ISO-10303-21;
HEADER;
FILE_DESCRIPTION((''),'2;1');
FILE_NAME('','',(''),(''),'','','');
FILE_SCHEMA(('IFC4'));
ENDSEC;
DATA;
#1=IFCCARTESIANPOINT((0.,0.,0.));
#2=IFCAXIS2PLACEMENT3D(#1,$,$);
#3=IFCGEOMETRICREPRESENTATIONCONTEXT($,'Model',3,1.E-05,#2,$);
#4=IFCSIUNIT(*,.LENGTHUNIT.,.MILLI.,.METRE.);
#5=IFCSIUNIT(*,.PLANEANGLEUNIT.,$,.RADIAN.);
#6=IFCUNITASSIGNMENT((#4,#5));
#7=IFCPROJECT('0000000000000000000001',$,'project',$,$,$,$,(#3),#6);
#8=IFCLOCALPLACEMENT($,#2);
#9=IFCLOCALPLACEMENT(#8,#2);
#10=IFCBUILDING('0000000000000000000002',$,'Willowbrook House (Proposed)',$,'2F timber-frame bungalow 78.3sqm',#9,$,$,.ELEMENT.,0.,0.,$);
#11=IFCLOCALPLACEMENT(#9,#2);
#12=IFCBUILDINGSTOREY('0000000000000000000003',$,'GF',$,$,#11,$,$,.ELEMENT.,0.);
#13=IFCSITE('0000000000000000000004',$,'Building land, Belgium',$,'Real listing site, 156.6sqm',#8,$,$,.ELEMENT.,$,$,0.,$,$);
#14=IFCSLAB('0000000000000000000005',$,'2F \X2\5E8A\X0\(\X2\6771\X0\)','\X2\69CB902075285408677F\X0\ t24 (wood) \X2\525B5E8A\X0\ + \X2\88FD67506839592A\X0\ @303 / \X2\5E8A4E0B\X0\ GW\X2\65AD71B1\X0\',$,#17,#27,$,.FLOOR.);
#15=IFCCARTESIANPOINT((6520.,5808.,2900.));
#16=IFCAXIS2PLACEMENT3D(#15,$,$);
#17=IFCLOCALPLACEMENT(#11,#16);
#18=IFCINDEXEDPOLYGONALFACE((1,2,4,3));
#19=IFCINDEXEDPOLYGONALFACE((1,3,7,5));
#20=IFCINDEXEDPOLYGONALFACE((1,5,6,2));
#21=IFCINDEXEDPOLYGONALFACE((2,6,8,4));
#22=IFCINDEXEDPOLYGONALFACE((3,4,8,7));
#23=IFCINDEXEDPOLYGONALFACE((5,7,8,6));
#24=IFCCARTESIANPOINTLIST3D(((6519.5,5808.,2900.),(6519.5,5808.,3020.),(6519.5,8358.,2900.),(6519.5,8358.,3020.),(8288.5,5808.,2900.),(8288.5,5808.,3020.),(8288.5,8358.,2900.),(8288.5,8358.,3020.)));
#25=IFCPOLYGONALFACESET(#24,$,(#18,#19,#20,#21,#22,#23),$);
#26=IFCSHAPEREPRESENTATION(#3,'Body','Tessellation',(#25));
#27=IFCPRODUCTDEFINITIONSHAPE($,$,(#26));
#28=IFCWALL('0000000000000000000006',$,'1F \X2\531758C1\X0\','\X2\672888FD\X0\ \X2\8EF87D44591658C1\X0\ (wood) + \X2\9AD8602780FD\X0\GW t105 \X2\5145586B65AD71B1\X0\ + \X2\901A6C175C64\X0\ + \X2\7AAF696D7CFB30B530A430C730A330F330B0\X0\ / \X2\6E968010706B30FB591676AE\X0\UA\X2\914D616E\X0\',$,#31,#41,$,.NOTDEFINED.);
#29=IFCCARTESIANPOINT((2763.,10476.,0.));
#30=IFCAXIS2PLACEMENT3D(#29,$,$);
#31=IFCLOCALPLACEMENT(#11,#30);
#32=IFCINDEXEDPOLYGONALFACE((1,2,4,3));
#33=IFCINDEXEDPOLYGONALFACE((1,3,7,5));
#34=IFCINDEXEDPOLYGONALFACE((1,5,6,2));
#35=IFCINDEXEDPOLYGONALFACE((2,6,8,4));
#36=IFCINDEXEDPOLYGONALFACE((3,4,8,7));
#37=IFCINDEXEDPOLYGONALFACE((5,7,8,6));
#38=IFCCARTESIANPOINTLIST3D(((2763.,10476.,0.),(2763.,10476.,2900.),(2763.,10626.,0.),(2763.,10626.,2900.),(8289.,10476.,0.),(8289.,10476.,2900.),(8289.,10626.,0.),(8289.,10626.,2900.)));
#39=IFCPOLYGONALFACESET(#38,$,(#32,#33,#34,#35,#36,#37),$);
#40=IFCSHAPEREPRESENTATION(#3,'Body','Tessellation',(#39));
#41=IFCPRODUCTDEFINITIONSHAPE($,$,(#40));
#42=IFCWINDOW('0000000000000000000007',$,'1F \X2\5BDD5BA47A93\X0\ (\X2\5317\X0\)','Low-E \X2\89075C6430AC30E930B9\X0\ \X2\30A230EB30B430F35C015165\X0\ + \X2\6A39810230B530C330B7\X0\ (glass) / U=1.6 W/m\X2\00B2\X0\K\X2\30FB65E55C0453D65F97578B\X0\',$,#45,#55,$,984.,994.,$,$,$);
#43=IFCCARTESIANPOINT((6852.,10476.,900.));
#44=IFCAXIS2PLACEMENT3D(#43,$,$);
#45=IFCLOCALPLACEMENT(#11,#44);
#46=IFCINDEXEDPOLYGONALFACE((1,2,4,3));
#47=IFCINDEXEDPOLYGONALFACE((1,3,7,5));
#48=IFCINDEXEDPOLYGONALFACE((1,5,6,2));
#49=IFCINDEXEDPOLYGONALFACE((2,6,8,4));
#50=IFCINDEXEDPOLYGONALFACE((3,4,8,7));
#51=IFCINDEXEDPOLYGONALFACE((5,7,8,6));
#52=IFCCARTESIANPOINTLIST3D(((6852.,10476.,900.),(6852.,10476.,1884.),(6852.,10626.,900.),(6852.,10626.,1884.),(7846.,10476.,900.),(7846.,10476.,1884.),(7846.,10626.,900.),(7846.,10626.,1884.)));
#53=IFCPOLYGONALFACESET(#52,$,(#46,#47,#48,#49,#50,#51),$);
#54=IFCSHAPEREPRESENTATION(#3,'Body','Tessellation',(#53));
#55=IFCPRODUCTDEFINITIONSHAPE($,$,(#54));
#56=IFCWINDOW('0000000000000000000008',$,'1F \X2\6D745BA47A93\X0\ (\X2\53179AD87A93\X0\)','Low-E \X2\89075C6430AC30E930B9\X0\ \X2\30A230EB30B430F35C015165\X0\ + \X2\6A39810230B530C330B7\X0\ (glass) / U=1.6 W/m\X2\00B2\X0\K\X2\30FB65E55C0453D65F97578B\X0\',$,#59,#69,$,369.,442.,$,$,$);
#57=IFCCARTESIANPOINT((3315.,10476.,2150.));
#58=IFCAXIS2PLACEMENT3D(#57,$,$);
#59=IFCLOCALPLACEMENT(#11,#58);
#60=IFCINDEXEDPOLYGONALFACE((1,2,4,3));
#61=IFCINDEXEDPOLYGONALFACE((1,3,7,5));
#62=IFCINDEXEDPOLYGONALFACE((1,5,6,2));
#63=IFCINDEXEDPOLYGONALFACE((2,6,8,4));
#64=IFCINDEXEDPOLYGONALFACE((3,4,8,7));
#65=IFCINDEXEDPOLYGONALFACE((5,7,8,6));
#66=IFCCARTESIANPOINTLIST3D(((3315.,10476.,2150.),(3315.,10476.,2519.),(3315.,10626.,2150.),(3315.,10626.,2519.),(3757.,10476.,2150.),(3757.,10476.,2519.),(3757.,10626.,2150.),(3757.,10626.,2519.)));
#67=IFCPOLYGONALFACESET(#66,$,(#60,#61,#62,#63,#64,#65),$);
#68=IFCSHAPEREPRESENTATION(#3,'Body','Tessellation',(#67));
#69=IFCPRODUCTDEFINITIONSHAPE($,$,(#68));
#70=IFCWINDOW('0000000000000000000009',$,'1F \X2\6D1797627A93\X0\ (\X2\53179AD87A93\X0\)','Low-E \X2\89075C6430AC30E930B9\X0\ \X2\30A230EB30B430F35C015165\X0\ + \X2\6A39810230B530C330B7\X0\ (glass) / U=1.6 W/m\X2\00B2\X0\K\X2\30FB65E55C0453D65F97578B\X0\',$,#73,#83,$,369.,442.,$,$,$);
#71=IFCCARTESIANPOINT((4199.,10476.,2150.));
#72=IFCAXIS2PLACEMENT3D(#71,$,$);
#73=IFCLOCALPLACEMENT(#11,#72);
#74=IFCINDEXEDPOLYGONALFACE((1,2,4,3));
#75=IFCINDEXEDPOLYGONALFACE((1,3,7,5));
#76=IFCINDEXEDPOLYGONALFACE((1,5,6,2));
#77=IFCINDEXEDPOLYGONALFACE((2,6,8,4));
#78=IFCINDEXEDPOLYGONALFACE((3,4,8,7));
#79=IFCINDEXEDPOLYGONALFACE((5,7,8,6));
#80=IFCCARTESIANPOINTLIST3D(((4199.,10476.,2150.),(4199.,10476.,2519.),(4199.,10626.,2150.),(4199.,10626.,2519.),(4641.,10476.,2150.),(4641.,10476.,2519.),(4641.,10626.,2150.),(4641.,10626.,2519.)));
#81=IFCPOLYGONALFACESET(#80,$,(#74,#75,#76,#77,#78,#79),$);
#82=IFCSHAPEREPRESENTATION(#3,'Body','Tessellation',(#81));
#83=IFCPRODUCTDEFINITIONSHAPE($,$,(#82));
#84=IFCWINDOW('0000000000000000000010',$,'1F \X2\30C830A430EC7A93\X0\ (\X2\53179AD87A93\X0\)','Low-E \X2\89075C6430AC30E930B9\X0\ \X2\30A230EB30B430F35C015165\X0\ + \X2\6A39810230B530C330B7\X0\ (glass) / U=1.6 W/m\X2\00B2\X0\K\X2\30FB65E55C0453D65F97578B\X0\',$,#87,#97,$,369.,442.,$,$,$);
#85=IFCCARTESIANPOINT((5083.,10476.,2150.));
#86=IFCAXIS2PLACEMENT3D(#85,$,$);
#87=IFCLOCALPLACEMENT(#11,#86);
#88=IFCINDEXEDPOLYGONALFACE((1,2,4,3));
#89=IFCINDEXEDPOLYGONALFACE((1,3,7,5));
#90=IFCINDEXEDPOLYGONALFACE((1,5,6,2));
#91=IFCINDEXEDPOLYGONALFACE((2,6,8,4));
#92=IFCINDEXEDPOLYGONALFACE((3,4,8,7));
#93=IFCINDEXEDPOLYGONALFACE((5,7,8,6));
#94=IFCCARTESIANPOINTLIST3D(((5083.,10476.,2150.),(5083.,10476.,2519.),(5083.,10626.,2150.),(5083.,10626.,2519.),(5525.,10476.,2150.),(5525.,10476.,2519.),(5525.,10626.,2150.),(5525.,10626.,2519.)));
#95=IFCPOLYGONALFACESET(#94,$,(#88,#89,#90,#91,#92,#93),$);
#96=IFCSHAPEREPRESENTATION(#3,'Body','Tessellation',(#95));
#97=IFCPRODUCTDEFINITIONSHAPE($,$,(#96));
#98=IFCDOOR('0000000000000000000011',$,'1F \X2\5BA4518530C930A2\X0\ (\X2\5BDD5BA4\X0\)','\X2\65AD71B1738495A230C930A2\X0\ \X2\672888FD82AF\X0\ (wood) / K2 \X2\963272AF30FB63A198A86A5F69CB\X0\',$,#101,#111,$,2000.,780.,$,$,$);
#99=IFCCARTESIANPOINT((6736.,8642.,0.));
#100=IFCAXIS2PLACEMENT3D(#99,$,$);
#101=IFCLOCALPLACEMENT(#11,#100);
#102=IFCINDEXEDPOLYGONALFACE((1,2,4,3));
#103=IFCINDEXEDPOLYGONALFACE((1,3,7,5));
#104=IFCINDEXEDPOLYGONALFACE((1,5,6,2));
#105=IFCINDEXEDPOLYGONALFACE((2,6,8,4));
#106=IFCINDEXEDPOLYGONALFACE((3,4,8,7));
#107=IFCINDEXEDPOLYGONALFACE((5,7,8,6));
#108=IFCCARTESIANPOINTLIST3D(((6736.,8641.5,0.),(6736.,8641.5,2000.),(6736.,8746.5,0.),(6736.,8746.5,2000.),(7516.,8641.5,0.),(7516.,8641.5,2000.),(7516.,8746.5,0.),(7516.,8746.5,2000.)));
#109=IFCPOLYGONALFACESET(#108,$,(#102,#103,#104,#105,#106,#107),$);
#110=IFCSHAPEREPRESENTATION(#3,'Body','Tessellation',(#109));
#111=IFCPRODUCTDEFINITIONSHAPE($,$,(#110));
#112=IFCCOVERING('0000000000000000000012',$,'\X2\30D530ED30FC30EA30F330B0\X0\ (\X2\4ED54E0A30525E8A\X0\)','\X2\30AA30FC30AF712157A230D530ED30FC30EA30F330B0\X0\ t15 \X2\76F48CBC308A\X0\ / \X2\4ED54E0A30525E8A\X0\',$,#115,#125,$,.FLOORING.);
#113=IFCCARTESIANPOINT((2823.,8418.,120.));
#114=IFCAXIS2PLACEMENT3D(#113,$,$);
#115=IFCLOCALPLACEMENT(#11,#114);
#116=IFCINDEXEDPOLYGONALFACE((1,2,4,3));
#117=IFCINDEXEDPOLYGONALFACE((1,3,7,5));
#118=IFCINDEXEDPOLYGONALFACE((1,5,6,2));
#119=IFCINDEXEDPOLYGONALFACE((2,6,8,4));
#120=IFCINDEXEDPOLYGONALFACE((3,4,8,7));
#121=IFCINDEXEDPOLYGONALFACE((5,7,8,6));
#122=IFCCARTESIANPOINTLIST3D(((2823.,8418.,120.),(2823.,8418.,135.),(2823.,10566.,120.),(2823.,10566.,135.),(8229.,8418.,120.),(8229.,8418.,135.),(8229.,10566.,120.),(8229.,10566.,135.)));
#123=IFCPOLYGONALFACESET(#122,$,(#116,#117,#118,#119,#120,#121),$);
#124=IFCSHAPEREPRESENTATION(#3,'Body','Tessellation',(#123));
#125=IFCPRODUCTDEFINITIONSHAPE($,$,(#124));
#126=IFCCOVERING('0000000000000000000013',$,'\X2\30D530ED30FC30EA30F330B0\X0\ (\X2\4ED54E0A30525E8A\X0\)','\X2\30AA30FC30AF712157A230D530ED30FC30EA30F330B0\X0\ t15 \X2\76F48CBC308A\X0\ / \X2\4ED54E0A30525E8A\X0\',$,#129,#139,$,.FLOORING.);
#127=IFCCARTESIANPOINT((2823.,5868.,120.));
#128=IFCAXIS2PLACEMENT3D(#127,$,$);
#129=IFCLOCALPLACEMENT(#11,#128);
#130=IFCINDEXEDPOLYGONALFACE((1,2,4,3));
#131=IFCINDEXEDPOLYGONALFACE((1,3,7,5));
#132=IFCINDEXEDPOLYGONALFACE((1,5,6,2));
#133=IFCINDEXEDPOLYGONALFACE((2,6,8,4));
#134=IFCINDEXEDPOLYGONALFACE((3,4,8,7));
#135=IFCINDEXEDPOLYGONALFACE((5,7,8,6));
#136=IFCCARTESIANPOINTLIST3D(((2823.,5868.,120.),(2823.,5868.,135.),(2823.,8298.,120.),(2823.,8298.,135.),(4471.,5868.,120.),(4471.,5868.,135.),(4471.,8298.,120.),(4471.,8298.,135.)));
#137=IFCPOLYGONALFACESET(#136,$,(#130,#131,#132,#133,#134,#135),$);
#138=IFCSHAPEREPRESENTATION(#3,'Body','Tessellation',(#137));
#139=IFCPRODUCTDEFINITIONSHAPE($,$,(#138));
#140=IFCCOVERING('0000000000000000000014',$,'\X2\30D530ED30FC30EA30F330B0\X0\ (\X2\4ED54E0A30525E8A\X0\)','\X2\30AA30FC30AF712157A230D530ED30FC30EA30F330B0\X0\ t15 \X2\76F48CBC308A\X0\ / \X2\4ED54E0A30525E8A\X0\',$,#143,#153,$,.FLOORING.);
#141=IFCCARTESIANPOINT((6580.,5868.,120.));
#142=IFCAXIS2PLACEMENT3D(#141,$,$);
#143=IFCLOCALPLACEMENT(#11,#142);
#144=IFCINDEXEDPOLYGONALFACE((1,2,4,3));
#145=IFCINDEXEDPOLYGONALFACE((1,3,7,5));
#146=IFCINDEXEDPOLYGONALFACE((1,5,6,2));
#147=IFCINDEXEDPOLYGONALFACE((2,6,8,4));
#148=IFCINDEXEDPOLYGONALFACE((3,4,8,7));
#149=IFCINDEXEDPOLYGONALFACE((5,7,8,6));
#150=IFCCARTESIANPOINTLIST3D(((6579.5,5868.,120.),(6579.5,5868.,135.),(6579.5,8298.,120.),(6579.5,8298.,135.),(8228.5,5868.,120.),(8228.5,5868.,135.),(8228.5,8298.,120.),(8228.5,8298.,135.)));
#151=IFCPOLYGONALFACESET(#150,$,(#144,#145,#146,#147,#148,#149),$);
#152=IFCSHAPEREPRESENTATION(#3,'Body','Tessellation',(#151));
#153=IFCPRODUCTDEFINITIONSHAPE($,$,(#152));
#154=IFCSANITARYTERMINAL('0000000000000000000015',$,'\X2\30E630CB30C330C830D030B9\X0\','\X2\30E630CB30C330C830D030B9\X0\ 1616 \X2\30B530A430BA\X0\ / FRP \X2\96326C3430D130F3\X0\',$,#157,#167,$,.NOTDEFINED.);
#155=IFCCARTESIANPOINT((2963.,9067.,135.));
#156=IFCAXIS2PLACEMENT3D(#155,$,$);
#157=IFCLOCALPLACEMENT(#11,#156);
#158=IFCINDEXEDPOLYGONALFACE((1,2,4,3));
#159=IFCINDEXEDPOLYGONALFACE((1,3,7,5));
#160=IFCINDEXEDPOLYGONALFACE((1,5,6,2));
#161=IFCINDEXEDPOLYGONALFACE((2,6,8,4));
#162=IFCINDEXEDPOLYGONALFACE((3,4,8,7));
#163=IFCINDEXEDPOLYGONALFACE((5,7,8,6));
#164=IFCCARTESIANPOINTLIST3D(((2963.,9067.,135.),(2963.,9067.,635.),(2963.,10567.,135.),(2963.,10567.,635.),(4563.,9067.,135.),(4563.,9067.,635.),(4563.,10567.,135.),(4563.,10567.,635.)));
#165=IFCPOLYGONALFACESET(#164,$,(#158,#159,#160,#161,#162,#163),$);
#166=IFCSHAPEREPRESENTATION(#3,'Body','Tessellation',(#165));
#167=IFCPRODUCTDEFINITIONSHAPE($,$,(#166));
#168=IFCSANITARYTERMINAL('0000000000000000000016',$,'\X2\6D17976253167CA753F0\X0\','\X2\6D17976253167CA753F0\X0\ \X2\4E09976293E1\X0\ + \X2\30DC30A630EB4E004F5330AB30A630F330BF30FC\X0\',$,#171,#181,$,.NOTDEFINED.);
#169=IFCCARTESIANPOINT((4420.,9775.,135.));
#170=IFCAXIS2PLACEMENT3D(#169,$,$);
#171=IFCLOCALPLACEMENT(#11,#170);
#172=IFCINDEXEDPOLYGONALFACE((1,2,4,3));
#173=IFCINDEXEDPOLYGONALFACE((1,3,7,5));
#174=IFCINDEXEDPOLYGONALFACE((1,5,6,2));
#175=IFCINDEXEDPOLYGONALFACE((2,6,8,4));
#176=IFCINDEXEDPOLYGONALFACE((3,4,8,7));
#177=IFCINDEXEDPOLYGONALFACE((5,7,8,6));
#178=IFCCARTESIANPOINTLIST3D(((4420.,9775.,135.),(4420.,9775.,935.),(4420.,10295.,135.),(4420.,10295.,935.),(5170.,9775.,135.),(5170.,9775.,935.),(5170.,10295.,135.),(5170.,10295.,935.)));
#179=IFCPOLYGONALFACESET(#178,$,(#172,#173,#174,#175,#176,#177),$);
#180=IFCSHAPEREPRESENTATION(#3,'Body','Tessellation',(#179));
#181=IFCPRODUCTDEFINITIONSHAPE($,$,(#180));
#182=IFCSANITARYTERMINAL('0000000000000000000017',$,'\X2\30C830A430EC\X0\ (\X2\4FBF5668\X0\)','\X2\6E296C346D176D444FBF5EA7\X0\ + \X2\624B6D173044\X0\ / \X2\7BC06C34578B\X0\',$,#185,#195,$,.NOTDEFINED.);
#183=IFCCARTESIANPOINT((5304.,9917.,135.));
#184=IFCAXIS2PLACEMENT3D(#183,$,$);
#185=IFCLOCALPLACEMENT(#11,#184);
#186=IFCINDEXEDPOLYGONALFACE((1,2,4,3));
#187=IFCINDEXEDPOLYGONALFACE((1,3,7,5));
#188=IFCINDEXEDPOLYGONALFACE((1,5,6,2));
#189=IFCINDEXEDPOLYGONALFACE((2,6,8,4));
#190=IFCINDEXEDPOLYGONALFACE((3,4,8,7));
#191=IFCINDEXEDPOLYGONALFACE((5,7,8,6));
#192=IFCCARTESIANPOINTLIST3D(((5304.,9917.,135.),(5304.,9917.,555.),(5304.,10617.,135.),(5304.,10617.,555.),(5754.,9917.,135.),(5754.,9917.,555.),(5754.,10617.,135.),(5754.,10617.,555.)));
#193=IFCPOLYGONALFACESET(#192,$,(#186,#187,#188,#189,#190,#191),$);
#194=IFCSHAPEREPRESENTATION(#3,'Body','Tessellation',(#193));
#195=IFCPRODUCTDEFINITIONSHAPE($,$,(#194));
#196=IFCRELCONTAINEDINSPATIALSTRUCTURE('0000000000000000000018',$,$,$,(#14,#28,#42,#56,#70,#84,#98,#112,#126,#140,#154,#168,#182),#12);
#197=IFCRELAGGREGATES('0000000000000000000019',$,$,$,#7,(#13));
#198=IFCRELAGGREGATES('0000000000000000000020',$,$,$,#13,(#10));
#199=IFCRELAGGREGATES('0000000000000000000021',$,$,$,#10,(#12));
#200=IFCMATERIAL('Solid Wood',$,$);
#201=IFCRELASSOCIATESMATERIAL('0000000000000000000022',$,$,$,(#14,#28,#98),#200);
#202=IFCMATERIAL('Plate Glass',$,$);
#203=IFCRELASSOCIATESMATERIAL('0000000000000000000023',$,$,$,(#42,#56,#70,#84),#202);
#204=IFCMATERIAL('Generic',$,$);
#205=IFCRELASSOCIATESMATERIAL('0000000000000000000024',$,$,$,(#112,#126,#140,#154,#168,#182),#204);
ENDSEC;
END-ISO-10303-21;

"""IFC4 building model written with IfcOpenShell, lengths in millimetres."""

from ifc_helpers import new_model, si_unit, frame, frame_2d, origin, place, context, project, spatial, rectangle, extrude, material, element, fill, save


model = new_model("IFC4")

# Units and contexts
model_context = context("Model", 3, precision=1e-05, world=origin())
ifc_project = project(units=[si_unit("LENGTHUNIT", "METRE", prefix="MILLI"), si_unit("PLANEANGLEUNIT", "RADIAN")], contexts=[model_context])

# Site, building, storey
site_placement = place(None, origin())
site = spatial("IfcSite", under=ifc_project, at=site_placement, Name="Building land, Belgium", ObjectType="Real listing site, 156.6sqm", CompositionType="ELEMENT", RefElevation=0.0)
building_placement = place(site_placement, origin())
building = spatial("IfcBuilding", under=site, at=building_placement, Name="Willowbrook House (Proposed)", ObjectType="2F timber-frame bungalow 78.3sqm", CompositionType="ELEMENT", ElevationOfRefHeight=0.0, ElevationOfTerrain=0.0)
storey_placement = place(building_placement, origin())
storey = spatial("IfcBuildingStorey", under=building, at=storey_placement, Name="GF", CompositionType="ELEMENT", Elevation=0.0)

# Slab
ifc_material_1 = material(Name="Solid Wood")
slab_1_placement = place(storey_placement, frame((6520.0, 5808.0, 2900.0)))
element("IfcSlab", 1, at=slab_1_placement, inside=storey, material=ifc_material_1, Name="2F 床(東)", Description="構造用合板 t24 (wood) 剛床 + 製材根太 @303 / 床下 GW断熱", PredefinedType="FLOOR", context=model_context, shape_type="SweptSolid", body=[
    extrude(rectangle(XDim=1769.0, YDim=2550.0, at=frame_2d((884.0, 1275.0))), frame((6520.0, 5808.0, 2900.0)), (0.0, 0.0, 1.0), 120.0),
])

# Wall, openings, windows
wall_1_placement = place(storey_placement, frame((2763.0, 10476.0, 0.0)))
wall_1 = element("IfcWall", 2, at=wall_1_placement, inside=storey, material=ifc_material_1, Name="1F 北壁", Description="木製 軸組外壁 (wood) + 高性能GW t105 充填断熱 + 通気層 + 窯業系サイディング / 準耐火・外皮UA配慮", PredefinedType="NOTDEFINED", context=model_context, shape_type="SweptSolid", body=[
    extrude(rectangle(XDim=5526.0, YDim=150.0, at=frame_2d((2763.0, 75.0))), frame((2763.0, 10476.0, 0.0)), (0.0, 0.0, 1.0), 2900.0),
])
opening_1_placement = place(storey_placement, frame((6852.0, 10476.0, 900.0)))
opening_1 = element("IfcOpeningElement", 3, at=opening_1_placement, cuts=wall_1, PredefinedType="NOTDEFINED", context=model_context, shape_type="SweptSolid", body=[
    extrude(rectangle(XDim=994.0, YDim=150.0, at=frame_2d((497.0, 75.0))), frame((6852.0, 10476.0, 900.0)), (0.0, 0.0, 1.0), 984.0),
])
opening_2_placement = place(storey_placement, frame((3315.0, 10476.0, 2150.0)))
opening_2 = element("IfcOpeningElement", 4, at=opening_2_placement, cuts=wall_1, PredefinedType="NOTDEFINED", context=model_context, shape_type="SweptSolid", body=[
    extrude(rectangle(XDim=442.0, YDim=150.0, at=frame_2d((221.0, 75.0))), frame((3315.0, 10476.0, 2150.0)), (0.0, 0.0, 1.0), 369.0),
])
opening_3_placement = place(storey_placement, frame((4199.0, 10476.0, 2150.0)))
opening_3 = element("IfcOpeningElement", 5, at=opening_3_placement, cuts=wall_1, PredefinedType="NOTDEFINED", context=model_context, shape_type="SweptSolid", body=[
    extrude(rectangle(XDim=442.0, YDim=150.0, at=frame_2d((221.0, 75.0))), frame((4199.0, 10476.0, 2150.0)), (0.0, 0.0, 1.0), 369.0),
])
opening_4_placement = place(storey_placement, frame((5083.0, 10476.0, 2150.0)))
opening_4 = element("IfcOpeningElement", 6, at=opening_4_placement, cuts=wall_1, PredefinedType="NOTDEFINED", context=model_context, shape_type="SweptSolid", body=[
    extrude(rectangle(XDim=442.0, YDim=150.0, at=frame_2d((221.0, 75.0))), frame((5083.0, 10476.0, 2150.0)), (0.0, 0.0, 1.0), 369.0),
])
ifc_material_2 = material(Name="Plate Glass")
window_1_placement = place(storey_placement, frame((6852.0, 10476.0, 900.0)))
window_1 = element("IfcWindow", 7, at=window_1_placement, inside=storey, material=ifc_material_2, Name="1F 寝室窓 (北)", Description="Low-E 複層ガラス アルゴン封入 + 樹脂サッシ (glass) / U=1.6 W/m²K・日射取得型", OverallHeight=984.0, OverallWidth=994.0, context=model_context, shape_type="SweptSolid", body=[
    extrude(rectangle(XDim=994.0, YDim=150.0, at=frame_2d((497.0, 75.0))), frame((6852.0, 10476.0, 900.0)), (0.0, 0.0, 1.0), 984.0),
])
fill(opening_1, window_1)
window_2_placement = place(storey_placement, frame((3315.0, 10476.0, 2150.0)))
window_2 = element("IfcWindow", 8, at=window_2_placement, inside=storey, material=ifc_material_2, Name="1F 浴室窓 (北高窓)", Description="Low-E 複層ガラス アルゴン封入 + 樹脂サッシ (glass) / U=1.6 W/m²K・日射取得型", OverallHeight=369.0, OverallWidth=442.0, context=model_context, shape_type="SweptSolid", body=[
    extrude(rectangle(XDim=442.0, YDim=150.0, at=frame_2d((221.0, 75.0))), frame((3315.0, 10476.0, 2150.0)), (0.0, 0.0, 1.0), 369.0),
])
fill(opening_2, window_2)
window_3_placement = place(storey_placement, frame((4199.0, 10476.0, 2150.0)))
window_3 = element("IfcWindow", 9, at=window_3_placement, inside=storey, material=ifc_material_2, Name="1F 洗面窓 (北高窓)", Description="Low-E 複層ガラス アルゴン封入 + 樹脂サッシ (glass) / U=1.6 W/m²K・日射取得型", OverallHeight=369.0, OverallWidth=442.0, context=model_context, shape_type="SweptSolid", body=[
    extrude(rectangle(XDim=442.0, YDim=150.0, at=frame_2d((221.0, 75.0))), frame((4199.0, 10476.0, 2150.0)), (0.0, 0.0, 1.0), 369.0),
])
fill(opening_3, window_3)
window_4_placement = place(storey_placement, frame((5083.0, 10476.0, 2150.0)))
window_4 = element("IfcWindow", 10, at=window_4_placement, inside=storey, material=ifc_material_2, Name="1F トイレ窓 (北高窓)", Description="Low-E 複層ガラス アルゴン封入 + 樹脂サッシ (glass) / U=1.6 W/m²K・日射取得型", OverallHeight=369.0, OverallWidth=442.0, context=model_context, shape_type="SweptSolid", body=[
    extrude(rectangle(XDim=442.0, YDim=150.0, at=frame_2d((221.0, 75.0))), frame((5083.0, 10476.0, 2150.0)), (0.0, 0.0, 1.0), 369.0),
])
fill(opening_4, window_4)

# Door
door_1_placement = place(storey_placement, frame((6736.0, 8642.0, 0.0)))
element("IfcDoor", 11, at=door_1_placement, inside=storey, material=ifc_material_1, Name="1F 室内ドア (寝室)", Description="断熱玄関ドア 木製芯 (wood) / K2 防犯・採風機構", OverallHeight=2000.0, OverallWidth=780.0, context=model_context, shape_type="SweptSolid", body=[
    extrude(rectangle(XDim=780.0, YDim=105.0, at=frame_2d((390.0, 52.0))), frame((6736.0, 8642.0, 0.0)), (0.0, 0.0, 1.0), 2000.0),
])

# Coverings
ifc_material_3 = material(Name="Generic")
covering_1_placement = place(storey_placement, frame((2823.0, 8418.0, 120.0)))
element("IfcCovering", 12, at=covering_1_placement, inside=storey, material=ifc_material_3, Name="フローリング (仕上げ床)", Description="オーク無垢フローリング t15 直貼り / 仕上げ床", PredefinedType="FLOORING", context=model_context, shape_type="SweptSolid", body=[
    extrude(rectangle(XDim=5406.0, YDim=2148.0, at=frame_2d((2703.0, 1074.0))), frame((2823.0, 8418.0, 120.0)), (0.0, 0.0, 1.0), 15.0),
])
covering_2_placement = place(storey_placement, frame((2823.0, 5868.0, 120.0)))
element("IfcCovering", 13, at=covering_2_placement, inside=storey, material=ifc_material_3, Name="フローリング (仕上げ床)", Description="オーク無垢フローリング t15 直貼り / 仕上げ床", PredefinedType="FLOORING", context=model_context, shape_type="SweptSolid", body=[
    extrude(rectangle(XDim=1648.0, YDim=2430.0, at=frame_2d((824.0, 1215.0))), frame((2823.0, 5868.0, 120.0)), (0.0, 0.0, 1.0), 15.0),
])
covering_3_placement = place(storey_placement, frame((6580.0, 5868.0, 120.0)))
element("IfcCovering", 14, at=covering_3_placement, inside=storey, material=ifc_material_3, Name="フローリング (仕上げ床)", Description="オーク無垢フローリング t15 直貼り / 仕上げ床", PredefinedType="FLOORING", context=model_context, shape_type="SweptSolid", body=[
    extrude(rectangle(XDim=1649.0, YDim=2430.0, at=frame_2d((824.0, 1215.0))), frame((6580.0, 5868.0, 120.0)), (0.0, 0.0, 1.0), 15.0),
])

# Sanitary terminals
sanitary_terminal_1_placement = place(storey_placement, frame((2963.0, 9067.0, 135.0)))
element("IfcSanitaryTerminal", 15, at=sanitary_terminal_1_placement, inside=storey, material=ifc_material_3, Name="ユニットバス", Description="ユニットバス 1616 サイズ / FRP 防水パン", PredefinedType="NOTDEFINED", context=model_context, shape_type="SweptSolid", body=[
    extrude(rectangle(XDim=1600.0, YDim=1500.0, at=frame_2d((800.0, 750.0))), frame((2963.0, 9067.0, 135.0)), (0.0, 0.0, 1.0), 500.0),
])
sanitary_terminal_2_placement = place(storey_placement, frame((4420.0, 9775.0, 135.0)))
element("IfcSanitaryTerminal", 16, at=sanitary_terminal_2_placement, inside=storey, material=ifc_material_3, Name="洗面化粧台", Description="洗面化粧台 三面鏡 + ボウル一体カウンター", PredefinedType="NOTDEFINED", context=model_context, shape_type="SweptSolid", body=[
    extrude(rectangle(XDim=750.0, YDim=520.0, at=frame_2d((375.0, 260.0))), frame((4420.0, 9775.0, 135.0)), (0.0, 0.0, 1.0), 800.0),
])
sanitary_terminal_3_placement = place(storey_placement, frame((5304.0, 9917.0, 135.0)))
element("IfcSanitaryTerminal", 17, at=sanitary_terminal_3_placement, inside=storey, material=ifc_material_3, Name="トイレ (便器)", Description="温水洗浄便座 + 手洗い / 節水型", PredefinedType="NOTDEFINED", context=model_context, shape_type="SweptSolid", body=[
    extrude(rectangle(XDim=450.0, YDim=700.0, at=frame_2d((225.0, 350.0))), frame((5304.0, 9917.0, 135.0)), (0.0, 0.0, 1.0), 420.0),
])

save(model, "model.ifc")
